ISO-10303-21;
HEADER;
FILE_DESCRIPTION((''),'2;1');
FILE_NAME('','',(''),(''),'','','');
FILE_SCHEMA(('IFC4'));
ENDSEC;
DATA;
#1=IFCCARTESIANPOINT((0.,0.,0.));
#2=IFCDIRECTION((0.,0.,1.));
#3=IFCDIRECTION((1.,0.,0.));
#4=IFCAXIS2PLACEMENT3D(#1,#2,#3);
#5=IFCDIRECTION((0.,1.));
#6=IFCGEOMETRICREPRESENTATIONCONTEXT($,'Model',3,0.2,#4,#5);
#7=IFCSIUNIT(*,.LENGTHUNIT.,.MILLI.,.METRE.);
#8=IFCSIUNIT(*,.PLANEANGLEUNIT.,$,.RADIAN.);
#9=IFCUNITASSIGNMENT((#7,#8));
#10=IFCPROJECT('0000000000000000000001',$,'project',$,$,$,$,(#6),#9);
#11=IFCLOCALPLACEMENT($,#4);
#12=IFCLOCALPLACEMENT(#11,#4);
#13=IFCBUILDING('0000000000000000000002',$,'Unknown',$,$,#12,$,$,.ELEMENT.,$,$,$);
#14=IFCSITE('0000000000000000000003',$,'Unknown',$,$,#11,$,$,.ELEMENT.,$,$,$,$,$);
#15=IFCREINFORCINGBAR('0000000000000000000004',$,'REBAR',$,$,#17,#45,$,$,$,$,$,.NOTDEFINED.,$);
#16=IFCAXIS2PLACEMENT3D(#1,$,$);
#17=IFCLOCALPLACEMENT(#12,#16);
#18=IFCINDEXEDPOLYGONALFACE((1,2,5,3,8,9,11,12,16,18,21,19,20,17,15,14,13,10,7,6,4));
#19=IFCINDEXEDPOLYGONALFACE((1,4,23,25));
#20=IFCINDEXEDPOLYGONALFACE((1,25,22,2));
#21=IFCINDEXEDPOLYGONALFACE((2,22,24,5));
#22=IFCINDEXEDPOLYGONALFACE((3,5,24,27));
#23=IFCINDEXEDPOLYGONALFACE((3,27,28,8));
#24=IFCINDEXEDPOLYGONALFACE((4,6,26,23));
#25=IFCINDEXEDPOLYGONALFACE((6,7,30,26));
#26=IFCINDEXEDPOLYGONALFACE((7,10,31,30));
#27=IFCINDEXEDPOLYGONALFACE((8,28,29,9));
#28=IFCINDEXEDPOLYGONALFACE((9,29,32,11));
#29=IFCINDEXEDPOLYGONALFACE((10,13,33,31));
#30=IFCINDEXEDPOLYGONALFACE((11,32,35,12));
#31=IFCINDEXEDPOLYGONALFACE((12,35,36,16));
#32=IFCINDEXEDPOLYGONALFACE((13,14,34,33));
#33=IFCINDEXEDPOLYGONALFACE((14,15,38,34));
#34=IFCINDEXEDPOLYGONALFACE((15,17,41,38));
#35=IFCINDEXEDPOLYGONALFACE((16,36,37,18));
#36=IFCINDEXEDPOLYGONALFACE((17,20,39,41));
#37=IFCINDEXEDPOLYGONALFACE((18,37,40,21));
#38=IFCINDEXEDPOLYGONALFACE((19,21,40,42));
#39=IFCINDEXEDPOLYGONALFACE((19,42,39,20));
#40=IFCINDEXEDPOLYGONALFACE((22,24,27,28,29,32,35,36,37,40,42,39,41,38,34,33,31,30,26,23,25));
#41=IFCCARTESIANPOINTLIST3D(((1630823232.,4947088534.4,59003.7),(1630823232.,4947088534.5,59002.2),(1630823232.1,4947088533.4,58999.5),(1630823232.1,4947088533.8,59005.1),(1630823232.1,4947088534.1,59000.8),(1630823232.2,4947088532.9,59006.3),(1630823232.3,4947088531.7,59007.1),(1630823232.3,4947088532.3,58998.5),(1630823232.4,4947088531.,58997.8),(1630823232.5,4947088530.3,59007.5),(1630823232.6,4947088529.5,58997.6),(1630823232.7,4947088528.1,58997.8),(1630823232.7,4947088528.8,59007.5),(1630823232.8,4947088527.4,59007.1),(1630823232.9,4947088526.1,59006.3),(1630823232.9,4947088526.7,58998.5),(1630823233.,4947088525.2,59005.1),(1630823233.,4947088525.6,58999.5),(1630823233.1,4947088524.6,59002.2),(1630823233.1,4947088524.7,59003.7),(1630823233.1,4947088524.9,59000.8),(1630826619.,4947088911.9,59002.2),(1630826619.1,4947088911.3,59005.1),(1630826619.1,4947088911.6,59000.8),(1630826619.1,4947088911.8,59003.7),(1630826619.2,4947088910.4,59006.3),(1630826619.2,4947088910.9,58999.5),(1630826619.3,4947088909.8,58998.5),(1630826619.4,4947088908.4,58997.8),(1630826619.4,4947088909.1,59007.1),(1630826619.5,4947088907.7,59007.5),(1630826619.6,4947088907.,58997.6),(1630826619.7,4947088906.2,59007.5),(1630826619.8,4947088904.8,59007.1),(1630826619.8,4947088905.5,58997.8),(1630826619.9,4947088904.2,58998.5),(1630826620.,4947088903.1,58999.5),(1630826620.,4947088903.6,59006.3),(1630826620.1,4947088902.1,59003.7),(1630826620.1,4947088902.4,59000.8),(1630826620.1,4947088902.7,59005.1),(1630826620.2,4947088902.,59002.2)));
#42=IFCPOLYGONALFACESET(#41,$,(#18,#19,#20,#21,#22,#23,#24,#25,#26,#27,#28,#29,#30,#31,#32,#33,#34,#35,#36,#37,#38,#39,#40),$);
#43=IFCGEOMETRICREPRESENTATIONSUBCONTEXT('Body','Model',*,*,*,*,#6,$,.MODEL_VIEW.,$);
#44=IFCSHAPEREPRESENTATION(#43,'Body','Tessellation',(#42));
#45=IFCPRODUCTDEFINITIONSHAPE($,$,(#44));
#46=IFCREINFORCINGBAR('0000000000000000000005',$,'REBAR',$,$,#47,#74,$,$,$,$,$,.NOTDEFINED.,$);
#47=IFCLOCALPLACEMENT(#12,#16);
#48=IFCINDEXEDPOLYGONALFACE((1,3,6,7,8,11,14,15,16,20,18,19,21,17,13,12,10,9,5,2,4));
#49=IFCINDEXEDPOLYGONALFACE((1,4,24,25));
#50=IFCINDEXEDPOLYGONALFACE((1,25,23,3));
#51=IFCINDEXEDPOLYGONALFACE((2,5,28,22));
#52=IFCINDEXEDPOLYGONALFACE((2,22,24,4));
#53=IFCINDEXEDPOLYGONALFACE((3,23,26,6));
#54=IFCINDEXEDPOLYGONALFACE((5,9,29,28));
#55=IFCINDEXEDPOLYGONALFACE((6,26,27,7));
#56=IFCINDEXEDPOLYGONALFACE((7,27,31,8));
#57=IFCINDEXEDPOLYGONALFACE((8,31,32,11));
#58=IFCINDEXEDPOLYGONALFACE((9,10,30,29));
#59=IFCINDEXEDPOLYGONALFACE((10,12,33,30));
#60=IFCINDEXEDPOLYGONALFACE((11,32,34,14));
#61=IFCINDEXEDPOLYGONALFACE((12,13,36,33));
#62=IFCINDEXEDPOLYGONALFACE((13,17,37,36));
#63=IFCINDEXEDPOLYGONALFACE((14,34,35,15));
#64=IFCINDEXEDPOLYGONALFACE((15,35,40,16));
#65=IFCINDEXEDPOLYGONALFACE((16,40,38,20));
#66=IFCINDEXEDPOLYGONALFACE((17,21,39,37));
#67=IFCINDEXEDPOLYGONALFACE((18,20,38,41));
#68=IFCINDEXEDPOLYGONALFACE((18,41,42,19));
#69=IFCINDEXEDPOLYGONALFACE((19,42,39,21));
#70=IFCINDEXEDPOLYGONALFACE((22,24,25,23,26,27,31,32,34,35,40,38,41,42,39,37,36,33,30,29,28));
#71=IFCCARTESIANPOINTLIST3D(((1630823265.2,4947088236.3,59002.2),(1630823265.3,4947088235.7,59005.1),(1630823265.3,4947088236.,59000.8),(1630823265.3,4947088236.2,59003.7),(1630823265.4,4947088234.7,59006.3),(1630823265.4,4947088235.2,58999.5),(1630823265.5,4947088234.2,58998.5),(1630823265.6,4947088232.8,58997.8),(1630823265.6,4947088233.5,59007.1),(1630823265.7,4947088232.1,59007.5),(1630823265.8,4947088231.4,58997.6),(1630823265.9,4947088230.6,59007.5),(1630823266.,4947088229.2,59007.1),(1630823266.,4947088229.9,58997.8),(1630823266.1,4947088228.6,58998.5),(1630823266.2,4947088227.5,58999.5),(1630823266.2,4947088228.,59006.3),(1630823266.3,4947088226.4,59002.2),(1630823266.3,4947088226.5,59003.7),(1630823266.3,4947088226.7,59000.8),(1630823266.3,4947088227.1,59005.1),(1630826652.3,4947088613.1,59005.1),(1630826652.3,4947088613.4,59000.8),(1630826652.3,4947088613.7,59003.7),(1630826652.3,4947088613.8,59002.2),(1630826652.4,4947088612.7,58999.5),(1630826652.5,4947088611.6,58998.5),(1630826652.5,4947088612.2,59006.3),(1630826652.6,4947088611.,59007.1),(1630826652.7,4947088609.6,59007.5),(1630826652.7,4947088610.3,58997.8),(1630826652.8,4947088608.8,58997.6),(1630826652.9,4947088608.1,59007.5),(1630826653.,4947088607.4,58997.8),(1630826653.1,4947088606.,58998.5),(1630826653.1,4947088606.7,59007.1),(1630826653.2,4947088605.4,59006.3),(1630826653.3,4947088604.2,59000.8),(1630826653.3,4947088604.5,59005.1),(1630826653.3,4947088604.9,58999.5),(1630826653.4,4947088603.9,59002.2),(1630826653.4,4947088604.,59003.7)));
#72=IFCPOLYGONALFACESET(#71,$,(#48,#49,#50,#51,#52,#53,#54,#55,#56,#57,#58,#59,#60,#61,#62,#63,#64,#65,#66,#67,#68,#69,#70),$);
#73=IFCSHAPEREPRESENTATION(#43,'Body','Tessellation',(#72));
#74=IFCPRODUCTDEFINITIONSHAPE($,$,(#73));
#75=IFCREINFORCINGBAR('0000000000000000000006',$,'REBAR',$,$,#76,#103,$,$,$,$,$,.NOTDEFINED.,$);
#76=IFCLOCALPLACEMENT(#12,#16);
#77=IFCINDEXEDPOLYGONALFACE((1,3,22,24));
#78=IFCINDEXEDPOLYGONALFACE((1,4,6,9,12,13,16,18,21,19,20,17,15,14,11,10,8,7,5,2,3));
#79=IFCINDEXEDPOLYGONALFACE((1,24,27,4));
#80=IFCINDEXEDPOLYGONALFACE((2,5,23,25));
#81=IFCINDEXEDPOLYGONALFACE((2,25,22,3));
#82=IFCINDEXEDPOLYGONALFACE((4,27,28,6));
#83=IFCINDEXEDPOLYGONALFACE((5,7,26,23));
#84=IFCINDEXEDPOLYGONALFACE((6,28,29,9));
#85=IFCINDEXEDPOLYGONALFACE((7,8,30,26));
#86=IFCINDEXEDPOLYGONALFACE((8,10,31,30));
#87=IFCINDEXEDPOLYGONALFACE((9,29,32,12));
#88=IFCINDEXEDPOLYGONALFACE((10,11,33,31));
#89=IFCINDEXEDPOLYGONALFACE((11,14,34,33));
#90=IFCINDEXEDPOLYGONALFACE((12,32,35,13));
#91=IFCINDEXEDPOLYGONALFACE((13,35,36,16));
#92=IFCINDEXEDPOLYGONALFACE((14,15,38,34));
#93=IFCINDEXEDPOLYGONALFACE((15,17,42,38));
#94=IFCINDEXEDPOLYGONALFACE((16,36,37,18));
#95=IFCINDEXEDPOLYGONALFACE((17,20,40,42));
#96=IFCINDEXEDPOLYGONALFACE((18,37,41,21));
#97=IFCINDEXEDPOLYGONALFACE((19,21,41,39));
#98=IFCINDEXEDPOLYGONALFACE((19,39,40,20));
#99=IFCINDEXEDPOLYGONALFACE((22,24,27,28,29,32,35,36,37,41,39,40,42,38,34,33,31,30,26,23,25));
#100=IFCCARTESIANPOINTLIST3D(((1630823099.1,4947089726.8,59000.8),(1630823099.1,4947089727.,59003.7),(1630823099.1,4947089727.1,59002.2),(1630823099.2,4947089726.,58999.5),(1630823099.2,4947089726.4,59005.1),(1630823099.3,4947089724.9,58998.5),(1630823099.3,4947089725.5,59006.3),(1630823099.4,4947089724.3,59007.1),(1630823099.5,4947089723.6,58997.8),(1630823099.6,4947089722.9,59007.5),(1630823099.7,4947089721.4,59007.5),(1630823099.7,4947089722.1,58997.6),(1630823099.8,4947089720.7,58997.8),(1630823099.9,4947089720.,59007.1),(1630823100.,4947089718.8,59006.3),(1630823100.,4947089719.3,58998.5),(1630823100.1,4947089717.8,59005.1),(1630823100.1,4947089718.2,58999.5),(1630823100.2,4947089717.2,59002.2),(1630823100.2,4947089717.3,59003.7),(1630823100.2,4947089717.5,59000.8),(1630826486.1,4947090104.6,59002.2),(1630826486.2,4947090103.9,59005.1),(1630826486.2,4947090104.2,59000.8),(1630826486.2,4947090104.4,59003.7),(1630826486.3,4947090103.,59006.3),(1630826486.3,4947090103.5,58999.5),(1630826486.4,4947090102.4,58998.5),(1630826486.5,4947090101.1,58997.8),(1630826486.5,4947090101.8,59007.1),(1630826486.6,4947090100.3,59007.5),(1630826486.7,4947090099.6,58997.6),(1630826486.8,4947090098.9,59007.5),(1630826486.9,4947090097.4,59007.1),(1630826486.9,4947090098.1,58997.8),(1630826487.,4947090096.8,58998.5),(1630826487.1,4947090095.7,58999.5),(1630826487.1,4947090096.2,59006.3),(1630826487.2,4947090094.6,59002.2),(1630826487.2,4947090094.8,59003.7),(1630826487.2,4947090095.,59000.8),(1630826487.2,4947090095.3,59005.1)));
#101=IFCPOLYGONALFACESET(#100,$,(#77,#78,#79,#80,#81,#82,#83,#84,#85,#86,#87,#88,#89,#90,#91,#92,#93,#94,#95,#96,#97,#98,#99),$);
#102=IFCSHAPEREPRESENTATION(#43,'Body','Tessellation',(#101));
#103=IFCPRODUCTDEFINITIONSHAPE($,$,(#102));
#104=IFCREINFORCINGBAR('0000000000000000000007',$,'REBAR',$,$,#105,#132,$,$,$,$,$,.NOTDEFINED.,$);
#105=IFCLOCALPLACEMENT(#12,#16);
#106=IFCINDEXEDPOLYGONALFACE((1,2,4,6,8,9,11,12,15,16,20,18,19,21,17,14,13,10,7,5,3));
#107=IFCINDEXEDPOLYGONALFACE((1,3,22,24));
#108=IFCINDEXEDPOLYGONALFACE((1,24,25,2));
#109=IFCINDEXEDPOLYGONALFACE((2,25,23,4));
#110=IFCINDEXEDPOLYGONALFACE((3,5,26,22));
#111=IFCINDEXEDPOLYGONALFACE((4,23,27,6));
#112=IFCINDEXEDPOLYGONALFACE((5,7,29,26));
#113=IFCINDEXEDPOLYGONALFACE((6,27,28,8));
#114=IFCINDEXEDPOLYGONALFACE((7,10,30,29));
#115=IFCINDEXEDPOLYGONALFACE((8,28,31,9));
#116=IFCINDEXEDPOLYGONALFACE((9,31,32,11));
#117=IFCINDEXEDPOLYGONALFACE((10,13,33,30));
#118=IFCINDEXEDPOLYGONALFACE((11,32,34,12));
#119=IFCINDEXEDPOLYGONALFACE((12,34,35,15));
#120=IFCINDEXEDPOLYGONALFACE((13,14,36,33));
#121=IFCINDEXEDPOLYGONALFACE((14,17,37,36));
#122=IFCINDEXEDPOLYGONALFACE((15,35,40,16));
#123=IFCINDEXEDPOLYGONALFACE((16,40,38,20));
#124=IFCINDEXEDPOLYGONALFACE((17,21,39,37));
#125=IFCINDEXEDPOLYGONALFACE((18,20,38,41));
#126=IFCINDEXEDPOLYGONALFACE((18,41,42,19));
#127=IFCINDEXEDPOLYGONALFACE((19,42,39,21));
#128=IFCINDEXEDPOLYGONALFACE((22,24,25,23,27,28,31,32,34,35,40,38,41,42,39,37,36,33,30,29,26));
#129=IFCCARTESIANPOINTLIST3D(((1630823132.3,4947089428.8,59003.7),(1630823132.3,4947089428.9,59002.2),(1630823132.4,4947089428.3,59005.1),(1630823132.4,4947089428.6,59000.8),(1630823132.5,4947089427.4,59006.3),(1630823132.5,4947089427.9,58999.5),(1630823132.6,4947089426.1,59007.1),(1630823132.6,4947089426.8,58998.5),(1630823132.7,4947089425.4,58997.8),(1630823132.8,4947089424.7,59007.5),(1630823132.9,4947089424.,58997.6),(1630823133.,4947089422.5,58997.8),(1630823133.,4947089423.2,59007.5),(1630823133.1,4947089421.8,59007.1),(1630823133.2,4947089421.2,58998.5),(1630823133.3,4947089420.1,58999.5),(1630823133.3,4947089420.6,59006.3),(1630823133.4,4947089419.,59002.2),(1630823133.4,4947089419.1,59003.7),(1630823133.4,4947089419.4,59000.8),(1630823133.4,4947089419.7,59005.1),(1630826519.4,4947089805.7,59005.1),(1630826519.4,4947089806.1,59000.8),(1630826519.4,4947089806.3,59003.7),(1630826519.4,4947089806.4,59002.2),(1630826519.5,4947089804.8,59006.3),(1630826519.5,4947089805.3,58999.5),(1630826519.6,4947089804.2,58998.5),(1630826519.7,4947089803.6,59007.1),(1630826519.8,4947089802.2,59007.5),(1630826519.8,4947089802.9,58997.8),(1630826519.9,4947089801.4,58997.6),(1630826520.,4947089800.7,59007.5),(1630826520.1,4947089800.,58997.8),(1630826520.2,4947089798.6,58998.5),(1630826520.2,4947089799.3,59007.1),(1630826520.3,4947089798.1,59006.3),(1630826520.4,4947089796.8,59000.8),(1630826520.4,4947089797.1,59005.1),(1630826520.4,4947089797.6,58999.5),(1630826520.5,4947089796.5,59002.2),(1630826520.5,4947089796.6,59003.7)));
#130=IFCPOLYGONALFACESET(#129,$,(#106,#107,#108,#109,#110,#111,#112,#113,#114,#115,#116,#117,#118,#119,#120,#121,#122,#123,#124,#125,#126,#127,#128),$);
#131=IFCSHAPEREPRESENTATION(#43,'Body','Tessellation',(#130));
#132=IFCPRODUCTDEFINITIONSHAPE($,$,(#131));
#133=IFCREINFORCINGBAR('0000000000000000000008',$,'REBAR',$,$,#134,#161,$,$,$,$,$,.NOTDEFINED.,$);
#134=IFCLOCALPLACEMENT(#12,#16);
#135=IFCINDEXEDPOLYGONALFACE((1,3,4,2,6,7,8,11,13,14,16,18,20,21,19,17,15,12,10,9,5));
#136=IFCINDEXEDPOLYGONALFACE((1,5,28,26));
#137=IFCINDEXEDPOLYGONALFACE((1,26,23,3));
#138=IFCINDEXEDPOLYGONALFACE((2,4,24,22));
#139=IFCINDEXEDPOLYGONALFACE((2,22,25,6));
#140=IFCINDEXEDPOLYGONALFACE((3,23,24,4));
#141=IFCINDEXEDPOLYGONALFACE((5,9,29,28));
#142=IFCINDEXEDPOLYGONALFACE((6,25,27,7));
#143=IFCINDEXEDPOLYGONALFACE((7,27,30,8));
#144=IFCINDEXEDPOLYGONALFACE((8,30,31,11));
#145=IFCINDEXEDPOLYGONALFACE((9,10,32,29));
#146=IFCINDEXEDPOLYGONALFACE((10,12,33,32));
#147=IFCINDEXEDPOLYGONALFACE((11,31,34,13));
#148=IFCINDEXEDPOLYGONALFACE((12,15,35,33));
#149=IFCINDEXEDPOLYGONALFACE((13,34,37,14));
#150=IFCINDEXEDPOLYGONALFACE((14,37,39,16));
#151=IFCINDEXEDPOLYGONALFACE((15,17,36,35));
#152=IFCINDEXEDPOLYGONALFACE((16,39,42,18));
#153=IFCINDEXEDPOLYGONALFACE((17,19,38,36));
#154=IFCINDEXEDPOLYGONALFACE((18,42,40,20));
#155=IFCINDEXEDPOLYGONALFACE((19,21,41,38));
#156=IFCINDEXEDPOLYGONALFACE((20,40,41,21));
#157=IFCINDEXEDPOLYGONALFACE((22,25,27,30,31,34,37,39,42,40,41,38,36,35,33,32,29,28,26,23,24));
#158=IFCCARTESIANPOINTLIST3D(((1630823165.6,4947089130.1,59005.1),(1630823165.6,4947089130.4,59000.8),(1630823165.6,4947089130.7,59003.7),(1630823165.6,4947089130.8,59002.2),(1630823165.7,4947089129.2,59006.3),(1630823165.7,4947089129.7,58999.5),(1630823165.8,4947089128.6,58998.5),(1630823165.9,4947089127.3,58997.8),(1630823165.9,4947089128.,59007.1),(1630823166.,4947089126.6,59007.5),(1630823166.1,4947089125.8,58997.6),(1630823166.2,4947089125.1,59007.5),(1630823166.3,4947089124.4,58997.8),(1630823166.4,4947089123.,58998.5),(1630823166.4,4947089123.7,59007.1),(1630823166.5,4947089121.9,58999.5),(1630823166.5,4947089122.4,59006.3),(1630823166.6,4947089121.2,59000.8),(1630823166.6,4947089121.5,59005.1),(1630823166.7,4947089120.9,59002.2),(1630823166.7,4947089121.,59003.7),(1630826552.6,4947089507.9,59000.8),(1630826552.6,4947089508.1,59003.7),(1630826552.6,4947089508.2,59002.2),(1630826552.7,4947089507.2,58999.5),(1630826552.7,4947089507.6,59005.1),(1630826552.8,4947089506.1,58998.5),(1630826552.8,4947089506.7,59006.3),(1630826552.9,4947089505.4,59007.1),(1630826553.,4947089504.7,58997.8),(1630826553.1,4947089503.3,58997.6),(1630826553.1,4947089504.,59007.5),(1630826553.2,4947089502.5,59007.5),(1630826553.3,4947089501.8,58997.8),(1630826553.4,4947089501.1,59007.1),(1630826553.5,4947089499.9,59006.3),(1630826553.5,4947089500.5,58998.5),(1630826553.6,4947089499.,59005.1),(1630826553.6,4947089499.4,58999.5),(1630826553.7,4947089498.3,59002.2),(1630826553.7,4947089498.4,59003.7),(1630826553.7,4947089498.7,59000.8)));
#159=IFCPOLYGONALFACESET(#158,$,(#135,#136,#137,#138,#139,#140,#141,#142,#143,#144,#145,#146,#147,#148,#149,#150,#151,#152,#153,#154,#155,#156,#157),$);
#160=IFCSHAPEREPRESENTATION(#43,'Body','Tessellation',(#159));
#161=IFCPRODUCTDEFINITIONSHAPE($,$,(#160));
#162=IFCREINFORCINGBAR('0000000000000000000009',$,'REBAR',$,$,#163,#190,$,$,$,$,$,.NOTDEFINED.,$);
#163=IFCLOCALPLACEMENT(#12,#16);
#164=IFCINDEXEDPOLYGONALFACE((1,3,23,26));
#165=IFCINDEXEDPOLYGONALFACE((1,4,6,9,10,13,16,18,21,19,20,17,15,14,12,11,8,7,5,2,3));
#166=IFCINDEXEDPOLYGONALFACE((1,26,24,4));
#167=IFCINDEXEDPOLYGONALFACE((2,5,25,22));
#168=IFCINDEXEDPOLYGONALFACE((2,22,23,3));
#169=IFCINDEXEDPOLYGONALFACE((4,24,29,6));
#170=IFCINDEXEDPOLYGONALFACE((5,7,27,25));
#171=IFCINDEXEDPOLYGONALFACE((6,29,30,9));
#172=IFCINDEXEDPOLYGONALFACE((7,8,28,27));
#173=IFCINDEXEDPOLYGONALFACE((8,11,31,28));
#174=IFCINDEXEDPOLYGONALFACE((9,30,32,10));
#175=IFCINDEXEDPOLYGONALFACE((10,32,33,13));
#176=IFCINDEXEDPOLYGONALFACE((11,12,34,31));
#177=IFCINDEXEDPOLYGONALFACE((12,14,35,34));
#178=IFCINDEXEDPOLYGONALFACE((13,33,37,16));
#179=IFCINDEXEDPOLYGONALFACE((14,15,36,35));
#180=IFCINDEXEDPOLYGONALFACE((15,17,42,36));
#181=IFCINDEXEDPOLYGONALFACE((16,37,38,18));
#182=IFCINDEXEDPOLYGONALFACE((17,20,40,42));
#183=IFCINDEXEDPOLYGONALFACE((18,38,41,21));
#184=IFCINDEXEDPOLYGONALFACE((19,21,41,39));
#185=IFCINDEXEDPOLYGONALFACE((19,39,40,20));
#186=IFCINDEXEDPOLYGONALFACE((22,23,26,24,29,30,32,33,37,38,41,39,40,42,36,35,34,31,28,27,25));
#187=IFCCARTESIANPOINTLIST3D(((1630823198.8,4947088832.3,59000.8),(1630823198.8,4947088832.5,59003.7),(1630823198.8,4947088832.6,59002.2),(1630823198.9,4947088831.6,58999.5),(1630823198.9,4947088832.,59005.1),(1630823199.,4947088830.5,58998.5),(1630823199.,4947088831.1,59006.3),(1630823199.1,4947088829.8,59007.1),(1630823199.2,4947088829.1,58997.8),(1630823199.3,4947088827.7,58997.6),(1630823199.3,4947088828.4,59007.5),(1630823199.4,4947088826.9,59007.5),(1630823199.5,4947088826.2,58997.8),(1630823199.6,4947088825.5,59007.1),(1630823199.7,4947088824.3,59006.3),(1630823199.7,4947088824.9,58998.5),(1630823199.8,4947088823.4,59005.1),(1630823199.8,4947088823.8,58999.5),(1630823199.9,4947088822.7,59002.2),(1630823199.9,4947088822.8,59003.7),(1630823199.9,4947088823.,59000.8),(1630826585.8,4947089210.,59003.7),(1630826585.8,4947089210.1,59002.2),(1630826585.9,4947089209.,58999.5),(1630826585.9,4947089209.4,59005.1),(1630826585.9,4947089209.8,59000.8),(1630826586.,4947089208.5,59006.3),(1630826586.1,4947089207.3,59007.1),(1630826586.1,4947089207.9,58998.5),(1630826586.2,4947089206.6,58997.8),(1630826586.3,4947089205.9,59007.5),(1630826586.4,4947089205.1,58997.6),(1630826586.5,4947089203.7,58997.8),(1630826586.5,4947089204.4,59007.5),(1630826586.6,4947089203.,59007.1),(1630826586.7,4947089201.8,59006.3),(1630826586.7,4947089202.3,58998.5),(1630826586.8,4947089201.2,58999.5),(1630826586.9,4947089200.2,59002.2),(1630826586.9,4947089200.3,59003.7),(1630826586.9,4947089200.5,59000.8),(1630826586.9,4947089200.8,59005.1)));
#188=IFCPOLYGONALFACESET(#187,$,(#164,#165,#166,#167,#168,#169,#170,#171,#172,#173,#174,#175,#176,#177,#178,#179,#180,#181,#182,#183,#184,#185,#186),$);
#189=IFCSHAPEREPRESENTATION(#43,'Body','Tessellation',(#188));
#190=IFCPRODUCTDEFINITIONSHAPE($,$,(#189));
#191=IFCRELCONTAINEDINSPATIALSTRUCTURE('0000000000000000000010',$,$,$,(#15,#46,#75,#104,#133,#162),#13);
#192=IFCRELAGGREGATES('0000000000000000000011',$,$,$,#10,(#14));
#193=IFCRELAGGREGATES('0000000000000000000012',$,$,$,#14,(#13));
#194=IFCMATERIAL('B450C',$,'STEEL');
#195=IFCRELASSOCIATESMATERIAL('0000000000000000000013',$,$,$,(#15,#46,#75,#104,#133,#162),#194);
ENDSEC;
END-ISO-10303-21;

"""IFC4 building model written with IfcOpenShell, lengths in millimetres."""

from ifc_helpers import new_model, entity, si_unit, direction, frame, origin_with_axes, place, context, subcontext, project, spatial, material, element, save


model = new_model("IFC4")

# Units and contexts
model_context = context("Model", 3, precision=0.2, world=origin_with_axes(), true_north=direction((0.0, 1.0)))
body_context = subcontext(model_context, "Body", "Model", "MODEL_VIEW")
ifc_project = project(units=[si_unit("LENGTHUNIT", "METRE", prefix="MILLI"), si_unit("PLANEANGLEUNIT", "RADIAN")], contexts=[model_context])

# Site, building
site_placement = place(None, origin_with_axes())
site = spatial("IfcSite", under=ifc_project, at=site_placement, Name="Unknown", CompositionType="ELEMENT")
building_placement = place(site_placement, origin_with_axes())
building = spatial("IfcBuilding", under=site, at=building_placement, Name="Unknown", CompositionType="ELEMENT")

# Reinforcing bars
ifc_material = material(Name="B450C", Category="STEEL")
reinforcing_bar_1_placement = place(building_placement, frame((1630826619.6, 4947088907.0, 59002.6), z_axis=(0.000031, -0.000282, -1.0), x_axis=(-0.993847, -0.110757, 0.0)))
element("IfcReinforcingBar", 1, at=reinforcing_bar_1_placement, inside=building, material=ifc_material, Name="REBAR", PredefinedType="NOTDEFINED", context=body_context, shape_type="AdvancedSweptSolid", body=[
    entity("IfcSweptDiskSolid", entity("IfcIndexedPolyCurve", entity("IfcCartesianPointList3D", [[0.0, 0.0, 0.0], [3408.0, 0.0, 0.0]]), [entity("IfcLineIndex", [1, 2])]), 5.0),
])
reinforcing_bar_2_placement = place(building_placement, frame((1630826652.8, 4947088608.8, 59002.6), z_axis=(0.000031, -0.000282, -1.0), x_axis=(-0.993847, -0.110757, 0.0)))
element("IfcReinforcingBar", 2, at=reinforcing_bar_2_placement, inside=building, material=ifc_material, Name="REBAR", PredefinedType="NOTDEFINED", context=body_context, shape_type="AdvancedSweptSolid", body=[
    entity("IfcSweptDiskSolid", entity("IfcIndexedPolyCurve", entity("IfcCartesianPointList3D", [[0.0, 0.0, 0.0], [3408.0, 0.0, 0.0]]), [entity("IfcLineIndex", [1, 2])]), 5.0),
])
reinforcing_bar_3_placement = place(building_placement, frame((1630826486.7, 4947090099.6, 59002.6), z_axis=(0.000031, -0.000282, -1.0), x_axis=(-0.993847, -0.110757, 0.0)))
element("IfcReinforcingBar", 3, at=reinforcing_bar_3_placement, inside=building, material=ifc_material, Name="REBAR", PredefinedType="NOTDEFINED", context=body_context, shape_type="AdvancedSweptSolid", body=[
    entity("IfcSweptDiskSolid", entity("IfcIndexedPolyCurve", entity("IfcCartesianPointList3D", [[0.0, 0.0, 0.0], [3408.0, 0.0, 0.0]]), [entity("IfcLineIndex", [1, 2])]), 5.0),
])
for number, where, z_axis, x_axis, name in (
    (4, (1630826519.9, 4947089801.4, 59002.6), (0.000031, -0.000282, -1.0), (-0.993847, -0.110757, 0.0), "REBAR"),
    (5, (1630826553.1, 4947089503.3, 59002.6), (0.000031, -0.000282, -1.0), (-0.993847, -0.110757, 0.0), "REBAR"),
    (6, (1630826586.4, 4947089205.1, 59002.6), (0.000031, -0.000282, -1.0), (-0.993847, -0.110757, 0.0), "REBAR"),
):
    element("IfcReinforcingBar", number, at=place(building_placement, frame(where, z_axis=z_axis, x_axis=x_axis)), inside=building, material=ifc_material, Name=name, PredefinedType="NOTDEFINED", context=body_context, shape_type="AdvancedSweptSolid", body=[
        entity("IfcSweptDiskSolid", entity("IfcIndexedPolyCurve", entity("IfcCartesianPointList3D", [[0.0, 0.0, 0.0], [3408.0, 0.0, 0.0]]), [entity("IfcLineIndex", [1, 2])]), 5.0),
    ])

save(model, "model.ifc")
